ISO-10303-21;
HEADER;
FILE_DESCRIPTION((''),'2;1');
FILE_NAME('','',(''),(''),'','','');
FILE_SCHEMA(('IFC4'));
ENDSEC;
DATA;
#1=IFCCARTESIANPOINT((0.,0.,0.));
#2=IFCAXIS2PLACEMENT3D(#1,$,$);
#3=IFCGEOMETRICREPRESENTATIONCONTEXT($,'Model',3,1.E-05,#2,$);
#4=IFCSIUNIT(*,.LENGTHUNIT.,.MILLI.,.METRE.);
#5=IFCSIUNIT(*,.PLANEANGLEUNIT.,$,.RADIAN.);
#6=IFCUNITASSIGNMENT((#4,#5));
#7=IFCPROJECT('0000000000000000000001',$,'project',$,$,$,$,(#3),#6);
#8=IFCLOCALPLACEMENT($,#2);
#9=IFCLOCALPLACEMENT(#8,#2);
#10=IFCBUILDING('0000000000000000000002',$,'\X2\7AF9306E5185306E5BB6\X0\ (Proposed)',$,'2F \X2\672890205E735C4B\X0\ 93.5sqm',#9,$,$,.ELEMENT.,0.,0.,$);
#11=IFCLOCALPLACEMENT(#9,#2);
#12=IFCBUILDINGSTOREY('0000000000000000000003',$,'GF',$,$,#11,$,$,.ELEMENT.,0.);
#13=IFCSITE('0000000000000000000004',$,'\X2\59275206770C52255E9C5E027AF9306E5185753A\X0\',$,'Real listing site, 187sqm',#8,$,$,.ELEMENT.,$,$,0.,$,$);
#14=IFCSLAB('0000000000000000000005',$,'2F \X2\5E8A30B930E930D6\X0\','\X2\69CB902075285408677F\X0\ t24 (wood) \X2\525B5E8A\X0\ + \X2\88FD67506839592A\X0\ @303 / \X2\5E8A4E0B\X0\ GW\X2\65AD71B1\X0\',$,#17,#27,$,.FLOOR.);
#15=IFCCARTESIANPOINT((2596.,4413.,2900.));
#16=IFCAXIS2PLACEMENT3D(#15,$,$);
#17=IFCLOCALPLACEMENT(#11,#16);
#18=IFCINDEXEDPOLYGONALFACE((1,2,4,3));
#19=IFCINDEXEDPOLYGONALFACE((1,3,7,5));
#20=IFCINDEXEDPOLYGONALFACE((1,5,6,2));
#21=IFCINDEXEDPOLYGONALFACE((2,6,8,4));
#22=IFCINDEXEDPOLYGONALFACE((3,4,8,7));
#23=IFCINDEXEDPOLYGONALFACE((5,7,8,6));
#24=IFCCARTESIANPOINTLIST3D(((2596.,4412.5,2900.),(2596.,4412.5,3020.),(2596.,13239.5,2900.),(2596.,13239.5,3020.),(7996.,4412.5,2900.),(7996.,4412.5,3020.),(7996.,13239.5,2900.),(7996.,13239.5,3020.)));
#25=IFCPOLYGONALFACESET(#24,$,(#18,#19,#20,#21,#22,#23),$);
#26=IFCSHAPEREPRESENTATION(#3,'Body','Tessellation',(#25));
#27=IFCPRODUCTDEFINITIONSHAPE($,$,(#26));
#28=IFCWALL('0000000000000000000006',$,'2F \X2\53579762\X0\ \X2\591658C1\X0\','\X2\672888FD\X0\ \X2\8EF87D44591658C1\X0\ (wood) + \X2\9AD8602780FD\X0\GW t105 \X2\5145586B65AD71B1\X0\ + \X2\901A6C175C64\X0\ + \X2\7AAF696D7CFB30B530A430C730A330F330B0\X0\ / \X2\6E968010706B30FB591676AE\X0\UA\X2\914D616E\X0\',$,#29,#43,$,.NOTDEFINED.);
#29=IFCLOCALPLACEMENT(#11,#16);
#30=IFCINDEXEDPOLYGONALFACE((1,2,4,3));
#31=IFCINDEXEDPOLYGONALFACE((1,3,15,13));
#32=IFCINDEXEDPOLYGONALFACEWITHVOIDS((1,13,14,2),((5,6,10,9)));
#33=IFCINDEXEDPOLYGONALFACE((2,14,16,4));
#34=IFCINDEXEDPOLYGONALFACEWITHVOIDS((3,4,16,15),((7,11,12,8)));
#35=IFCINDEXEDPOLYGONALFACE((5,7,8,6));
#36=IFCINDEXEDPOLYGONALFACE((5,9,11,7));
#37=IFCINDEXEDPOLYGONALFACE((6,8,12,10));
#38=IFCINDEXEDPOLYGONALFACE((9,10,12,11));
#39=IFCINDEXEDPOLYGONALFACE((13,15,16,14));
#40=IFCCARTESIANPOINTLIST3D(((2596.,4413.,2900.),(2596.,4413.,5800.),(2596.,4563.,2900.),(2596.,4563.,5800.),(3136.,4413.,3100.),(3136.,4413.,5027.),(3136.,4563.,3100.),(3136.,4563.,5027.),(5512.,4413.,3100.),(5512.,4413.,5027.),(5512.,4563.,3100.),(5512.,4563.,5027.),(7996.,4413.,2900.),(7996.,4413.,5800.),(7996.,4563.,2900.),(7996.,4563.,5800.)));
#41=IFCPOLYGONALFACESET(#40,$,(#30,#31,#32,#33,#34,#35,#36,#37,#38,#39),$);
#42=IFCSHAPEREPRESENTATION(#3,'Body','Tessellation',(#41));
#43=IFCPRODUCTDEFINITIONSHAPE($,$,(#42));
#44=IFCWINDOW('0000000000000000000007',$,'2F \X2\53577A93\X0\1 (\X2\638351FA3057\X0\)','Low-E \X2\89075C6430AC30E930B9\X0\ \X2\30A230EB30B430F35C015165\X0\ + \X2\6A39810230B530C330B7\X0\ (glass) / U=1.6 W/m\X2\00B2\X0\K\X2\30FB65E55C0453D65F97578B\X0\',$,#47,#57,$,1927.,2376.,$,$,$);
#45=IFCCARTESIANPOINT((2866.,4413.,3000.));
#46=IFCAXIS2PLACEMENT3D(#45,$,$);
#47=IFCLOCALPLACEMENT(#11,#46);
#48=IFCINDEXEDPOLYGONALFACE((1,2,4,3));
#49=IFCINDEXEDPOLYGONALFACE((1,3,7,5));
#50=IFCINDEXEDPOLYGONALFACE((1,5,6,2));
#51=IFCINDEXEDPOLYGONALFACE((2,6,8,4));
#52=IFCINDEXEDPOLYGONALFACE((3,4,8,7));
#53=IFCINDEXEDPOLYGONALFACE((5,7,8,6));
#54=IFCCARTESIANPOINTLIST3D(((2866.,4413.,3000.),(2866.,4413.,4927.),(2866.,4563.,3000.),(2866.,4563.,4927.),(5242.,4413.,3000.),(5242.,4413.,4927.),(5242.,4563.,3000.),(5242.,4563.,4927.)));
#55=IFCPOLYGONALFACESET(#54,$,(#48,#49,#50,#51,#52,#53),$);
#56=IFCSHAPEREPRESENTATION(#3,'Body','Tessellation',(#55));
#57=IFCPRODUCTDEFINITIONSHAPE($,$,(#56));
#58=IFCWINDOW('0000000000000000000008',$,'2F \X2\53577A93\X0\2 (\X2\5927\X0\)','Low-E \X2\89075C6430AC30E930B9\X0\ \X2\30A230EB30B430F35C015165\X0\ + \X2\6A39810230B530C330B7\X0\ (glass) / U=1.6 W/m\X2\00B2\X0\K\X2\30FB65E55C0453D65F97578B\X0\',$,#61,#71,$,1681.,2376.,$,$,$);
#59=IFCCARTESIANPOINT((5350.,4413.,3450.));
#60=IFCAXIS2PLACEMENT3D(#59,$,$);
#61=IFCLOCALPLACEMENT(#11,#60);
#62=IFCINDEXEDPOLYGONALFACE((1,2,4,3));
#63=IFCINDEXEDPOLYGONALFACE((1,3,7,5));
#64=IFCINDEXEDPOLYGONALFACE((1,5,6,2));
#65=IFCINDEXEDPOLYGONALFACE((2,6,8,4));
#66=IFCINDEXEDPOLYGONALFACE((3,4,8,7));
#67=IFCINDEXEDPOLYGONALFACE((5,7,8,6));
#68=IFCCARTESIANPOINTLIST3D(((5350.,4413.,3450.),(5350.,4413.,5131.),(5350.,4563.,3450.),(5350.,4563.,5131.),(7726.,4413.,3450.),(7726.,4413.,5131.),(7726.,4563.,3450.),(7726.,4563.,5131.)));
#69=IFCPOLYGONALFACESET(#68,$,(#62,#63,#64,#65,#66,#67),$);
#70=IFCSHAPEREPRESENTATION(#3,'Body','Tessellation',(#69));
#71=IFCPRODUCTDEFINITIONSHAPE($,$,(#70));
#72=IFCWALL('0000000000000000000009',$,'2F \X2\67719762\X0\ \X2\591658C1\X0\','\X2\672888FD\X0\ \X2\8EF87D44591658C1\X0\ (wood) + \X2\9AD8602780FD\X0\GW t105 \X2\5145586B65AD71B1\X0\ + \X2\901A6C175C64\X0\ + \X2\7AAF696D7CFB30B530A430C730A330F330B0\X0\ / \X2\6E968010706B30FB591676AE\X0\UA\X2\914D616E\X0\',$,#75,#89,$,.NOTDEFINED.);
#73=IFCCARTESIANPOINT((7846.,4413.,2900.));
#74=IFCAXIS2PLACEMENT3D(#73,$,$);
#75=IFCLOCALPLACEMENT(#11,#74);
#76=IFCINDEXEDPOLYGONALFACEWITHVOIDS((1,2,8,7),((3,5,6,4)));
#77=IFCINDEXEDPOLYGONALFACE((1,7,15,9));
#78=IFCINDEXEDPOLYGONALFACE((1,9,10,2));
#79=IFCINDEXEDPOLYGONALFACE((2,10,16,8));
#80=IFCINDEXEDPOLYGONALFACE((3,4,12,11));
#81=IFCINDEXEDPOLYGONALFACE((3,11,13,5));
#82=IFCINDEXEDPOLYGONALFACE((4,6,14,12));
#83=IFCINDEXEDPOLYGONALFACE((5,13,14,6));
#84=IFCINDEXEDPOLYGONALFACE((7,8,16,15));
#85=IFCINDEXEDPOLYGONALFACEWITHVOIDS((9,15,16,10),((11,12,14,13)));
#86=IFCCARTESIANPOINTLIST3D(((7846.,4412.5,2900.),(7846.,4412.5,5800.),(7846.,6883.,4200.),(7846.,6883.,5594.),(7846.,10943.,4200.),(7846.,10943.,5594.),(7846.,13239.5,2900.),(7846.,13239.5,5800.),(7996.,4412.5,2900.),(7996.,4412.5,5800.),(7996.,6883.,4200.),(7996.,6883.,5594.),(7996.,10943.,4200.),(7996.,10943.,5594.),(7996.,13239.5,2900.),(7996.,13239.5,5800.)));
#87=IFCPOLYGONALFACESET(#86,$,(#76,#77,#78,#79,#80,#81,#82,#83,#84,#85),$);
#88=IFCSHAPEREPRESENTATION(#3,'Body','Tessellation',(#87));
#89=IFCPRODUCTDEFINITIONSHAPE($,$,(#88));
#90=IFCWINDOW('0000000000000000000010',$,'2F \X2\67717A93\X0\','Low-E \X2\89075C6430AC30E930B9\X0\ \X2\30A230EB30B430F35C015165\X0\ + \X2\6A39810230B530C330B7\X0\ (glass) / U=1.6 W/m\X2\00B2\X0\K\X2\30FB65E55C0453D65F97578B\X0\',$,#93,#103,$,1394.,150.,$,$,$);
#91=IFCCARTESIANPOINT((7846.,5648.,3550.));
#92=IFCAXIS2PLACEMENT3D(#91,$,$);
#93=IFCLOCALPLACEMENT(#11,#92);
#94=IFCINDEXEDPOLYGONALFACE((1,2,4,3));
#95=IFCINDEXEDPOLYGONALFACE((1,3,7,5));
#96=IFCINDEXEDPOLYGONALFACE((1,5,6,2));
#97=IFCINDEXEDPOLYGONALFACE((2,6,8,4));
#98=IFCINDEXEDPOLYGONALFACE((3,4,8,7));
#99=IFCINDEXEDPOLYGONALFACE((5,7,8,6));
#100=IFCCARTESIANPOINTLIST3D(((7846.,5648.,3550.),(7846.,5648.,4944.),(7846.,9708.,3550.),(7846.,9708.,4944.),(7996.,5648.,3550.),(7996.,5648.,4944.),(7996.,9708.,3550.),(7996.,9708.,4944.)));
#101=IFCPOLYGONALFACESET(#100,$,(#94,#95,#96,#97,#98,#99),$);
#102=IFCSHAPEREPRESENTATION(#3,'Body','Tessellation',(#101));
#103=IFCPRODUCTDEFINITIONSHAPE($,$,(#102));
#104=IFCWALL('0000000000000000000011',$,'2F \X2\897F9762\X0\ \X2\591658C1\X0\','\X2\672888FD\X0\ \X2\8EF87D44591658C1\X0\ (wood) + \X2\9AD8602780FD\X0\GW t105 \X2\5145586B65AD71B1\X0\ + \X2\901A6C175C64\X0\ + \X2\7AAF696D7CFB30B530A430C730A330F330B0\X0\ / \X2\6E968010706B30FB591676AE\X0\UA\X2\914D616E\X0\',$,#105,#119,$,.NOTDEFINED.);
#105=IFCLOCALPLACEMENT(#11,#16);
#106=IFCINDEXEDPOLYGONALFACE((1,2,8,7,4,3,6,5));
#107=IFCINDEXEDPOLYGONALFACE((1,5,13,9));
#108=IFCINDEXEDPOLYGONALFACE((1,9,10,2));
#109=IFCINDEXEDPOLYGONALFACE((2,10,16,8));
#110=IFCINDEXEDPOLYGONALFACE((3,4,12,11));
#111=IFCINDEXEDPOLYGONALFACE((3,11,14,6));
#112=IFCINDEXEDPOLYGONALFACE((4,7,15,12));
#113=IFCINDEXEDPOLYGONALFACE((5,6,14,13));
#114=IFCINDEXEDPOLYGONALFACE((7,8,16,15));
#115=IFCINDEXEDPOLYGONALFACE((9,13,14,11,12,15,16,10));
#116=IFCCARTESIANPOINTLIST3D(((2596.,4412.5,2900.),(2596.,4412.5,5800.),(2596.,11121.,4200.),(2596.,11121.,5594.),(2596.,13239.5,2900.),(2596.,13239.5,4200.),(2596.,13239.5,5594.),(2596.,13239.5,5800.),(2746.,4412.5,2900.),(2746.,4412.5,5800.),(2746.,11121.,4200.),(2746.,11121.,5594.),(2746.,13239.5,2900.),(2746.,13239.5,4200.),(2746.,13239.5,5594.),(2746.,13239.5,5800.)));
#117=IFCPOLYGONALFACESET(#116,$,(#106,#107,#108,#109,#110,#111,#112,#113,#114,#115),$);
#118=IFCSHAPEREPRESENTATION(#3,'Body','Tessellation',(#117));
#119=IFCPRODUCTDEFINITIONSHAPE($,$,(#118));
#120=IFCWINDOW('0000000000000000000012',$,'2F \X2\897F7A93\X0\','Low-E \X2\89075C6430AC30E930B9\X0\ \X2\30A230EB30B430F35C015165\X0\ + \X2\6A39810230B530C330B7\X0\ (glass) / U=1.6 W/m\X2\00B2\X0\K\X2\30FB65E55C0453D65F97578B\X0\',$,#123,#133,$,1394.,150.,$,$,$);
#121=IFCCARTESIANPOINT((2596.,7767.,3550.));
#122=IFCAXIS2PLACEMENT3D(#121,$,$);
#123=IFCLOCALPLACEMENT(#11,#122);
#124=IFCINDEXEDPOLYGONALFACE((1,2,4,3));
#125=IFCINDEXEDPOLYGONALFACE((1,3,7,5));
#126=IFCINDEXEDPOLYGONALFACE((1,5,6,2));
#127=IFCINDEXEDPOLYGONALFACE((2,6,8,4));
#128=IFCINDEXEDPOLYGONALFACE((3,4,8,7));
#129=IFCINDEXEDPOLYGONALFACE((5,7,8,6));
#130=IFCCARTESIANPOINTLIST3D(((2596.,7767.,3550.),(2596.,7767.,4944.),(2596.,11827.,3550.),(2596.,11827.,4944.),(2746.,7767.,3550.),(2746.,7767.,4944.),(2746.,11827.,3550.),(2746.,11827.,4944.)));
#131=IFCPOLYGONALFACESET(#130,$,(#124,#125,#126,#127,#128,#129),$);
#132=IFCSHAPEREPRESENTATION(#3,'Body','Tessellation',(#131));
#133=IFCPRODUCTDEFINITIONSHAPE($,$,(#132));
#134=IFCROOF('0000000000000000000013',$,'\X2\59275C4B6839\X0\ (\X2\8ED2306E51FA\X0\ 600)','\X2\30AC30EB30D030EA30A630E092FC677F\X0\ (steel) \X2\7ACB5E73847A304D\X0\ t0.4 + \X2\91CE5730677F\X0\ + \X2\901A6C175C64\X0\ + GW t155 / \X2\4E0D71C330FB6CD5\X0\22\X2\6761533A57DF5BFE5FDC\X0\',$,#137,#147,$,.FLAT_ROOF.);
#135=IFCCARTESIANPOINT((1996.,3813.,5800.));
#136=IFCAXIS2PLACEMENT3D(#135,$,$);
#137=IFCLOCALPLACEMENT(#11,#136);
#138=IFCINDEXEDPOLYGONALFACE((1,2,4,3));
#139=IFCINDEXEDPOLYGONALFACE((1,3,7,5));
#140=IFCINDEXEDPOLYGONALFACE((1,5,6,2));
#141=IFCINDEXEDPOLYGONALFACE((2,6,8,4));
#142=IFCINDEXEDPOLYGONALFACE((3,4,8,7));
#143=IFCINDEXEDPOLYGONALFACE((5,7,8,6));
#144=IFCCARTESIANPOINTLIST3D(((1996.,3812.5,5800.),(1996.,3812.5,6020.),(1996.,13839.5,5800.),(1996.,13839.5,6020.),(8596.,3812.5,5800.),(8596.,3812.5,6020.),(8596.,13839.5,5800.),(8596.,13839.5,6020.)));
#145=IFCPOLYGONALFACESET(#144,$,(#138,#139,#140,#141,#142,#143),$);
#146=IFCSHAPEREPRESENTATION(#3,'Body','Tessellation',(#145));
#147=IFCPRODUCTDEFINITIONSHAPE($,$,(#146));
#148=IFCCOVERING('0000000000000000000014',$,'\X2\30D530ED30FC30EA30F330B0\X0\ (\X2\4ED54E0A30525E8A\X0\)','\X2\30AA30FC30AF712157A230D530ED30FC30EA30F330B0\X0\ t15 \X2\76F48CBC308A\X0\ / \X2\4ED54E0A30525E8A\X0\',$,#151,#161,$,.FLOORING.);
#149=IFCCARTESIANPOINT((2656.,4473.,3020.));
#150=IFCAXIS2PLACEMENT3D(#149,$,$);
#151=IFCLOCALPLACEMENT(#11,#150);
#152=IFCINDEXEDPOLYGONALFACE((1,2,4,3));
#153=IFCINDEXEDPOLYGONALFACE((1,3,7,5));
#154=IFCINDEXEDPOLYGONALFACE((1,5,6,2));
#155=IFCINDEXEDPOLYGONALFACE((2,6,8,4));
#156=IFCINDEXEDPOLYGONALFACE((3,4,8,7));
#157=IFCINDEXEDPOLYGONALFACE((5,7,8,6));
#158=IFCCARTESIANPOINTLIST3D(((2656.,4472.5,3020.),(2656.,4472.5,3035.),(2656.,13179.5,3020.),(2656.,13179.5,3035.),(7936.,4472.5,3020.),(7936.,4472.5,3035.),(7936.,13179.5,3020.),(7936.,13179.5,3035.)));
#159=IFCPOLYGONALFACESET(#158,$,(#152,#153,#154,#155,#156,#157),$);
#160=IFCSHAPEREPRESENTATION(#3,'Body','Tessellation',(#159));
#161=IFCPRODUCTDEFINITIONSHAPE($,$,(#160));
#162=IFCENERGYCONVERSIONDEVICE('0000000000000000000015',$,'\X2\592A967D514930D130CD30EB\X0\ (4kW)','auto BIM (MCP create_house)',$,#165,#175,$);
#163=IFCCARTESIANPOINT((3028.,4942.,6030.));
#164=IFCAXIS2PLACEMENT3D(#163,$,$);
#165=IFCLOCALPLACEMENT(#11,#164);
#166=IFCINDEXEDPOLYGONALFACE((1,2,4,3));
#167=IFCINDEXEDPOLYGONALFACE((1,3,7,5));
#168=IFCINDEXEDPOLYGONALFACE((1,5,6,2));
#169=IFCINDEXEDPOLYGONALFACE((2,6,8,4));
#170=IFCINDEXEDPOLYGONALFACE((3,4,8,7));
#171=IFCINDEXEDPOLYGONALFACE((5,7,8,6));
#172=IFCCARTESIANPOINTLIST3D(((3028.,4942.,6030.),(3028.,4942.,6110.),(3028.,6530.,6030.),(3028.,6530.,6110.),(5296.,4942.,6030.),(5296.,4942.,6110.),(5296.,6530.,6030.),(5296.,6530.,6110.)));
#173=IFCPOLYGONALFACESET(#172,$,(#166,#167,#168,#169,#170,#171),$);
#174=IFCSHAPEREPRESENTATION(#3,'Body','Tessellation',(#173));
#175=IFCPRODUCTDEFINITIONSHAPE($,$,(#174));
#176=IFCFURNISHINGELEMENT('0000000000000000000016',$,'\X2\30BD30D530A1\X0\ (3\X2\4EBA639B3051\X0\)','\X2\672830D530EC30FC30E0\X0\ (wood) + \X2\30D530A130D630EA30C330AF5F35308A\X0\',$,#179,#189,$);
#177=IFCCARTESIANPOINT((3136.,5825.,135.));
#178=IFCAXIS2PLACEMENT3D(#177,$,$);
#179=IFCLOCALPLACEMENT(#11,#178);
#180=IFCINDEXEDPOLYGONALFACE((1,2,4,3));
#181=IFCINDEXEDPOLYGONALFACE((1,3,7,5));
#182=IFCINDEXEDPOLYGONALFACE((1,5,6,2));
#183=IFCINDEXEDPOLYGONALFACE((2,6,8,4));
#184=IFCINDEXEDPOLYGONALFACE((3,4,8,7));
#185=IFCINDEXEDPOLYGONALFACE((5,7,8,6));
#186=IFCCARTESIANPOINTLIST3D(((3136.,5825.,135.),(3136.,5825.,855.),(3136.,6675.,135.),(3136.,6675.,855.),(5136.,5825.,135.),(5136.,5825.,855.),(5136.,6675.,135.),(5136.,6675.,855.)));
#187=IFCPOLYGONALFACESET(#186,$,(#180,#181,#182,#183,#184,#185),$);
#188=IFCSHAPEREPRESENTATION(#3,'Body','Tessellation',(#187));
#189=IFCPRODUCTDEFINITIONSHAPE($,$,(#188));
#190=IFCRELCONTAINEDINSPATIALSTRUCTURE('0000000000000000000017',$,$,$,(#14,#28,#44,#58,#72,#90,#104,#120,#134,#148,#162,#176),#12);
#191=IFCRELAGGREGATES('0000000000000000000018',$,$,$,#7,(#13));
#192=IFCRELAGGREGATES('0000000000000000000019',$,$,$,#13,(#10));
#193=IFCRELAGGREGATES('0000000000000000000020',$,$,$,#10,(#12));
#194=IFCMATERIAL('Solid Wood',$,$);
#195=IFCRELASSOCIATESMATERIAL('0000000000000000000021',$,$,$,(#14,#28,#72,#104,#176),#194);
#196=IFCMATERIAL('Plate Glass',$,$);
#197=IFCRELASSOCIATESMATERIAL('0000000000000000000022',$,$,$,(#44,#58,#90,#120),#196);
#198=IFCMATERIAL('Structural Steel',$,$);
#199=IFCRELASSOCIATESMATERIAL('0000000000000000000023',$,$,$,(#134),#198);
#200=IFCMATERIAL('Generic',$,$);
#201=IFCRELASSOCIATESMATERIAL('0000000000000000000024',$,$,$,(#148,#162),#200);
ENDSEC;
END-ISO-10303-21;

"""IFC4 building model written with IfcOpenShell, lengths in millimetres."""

from ifc_helpers import new_model, si_unit, frame, frame_2d, origin, place, context, project, spatial, rectangle, extrude, material, element, fill, save


model = new_model("IFC4")

# Units and contexts
model_context = context("Model", 3, precision=1e-05, world=origin())
ifc_project = project(units=[si_unit("LENGTHUNIT", "METRE", prefix="MILLI"), si_unit("PLANEANGLEUNIT", "RADIAN")], contexts=[model_context])

# Site, building, storey
site_placement = place(None, origin())
site = spatial("IfcSite", under=ifc_project, at=site_placement, Name="大分県別府市竹の内町", ObjectType="Real listing site, 187sqm", CompositionType="ELEMENT", RefElevation=0.0)
building_placement = place(site_placement, origin())
building = spatial("IfcBuilding", under=site, at=building_placement, Name="竹の内の家 (Proposed)", ObjectType="2F 木造平屋 93.5sqm", CompositionType="ELEMENT", ElevationOfRefHeight=0.0, ElevationOfTerrain=0.0)
storey_placement = place(building_placement, origin())
storey = spatial("IfcBuildingStorey", under=building, at=storey_placement, Name="GF", CompositionType="ELEMENT", Elevation=0.0)

# Slab
ifc_material_1 = material(Name="Solid Wood")
slab_placement = place(storey_placement, frame((2596.0, 4413.0, 2900.0)))
element("IfcSlab", 1, at=slab_placement, inside=storey, material=ifc_material_1, Name="2F 床スラブ", Description="構造用合板 t24 (wood) 剛床 + 製材根太 @303 / 床下 GW断熱", PredefinedType="FLOOR", context=model_context, shape_type="SweptSolid", body=[
    extrude(rectangle(XDim=5400.0, YDim=8827.0, at=frame_2d((2700.0, 4413.0))), frame((2596.0, 4413.0, 2900.0)), (0.0, 0.0, 1.0), 120.0),
])

# Wall, openings, windows
wall_1_placement = place(storey_placement, frame((2596.0, 4413.0, 2900.0)))
wall_1 = element("IfcWall", 2, at=wall_1_placement, inside=storey, material=ifc_material_1, Name="2F 南面 外壁", Description="木製 軸組外壁 (wood) + 高性能GW t105 充填断熱 + 通気層 + 窯業系サイディング / 準耐火・外皮UA配慮", PredefinedType="NOTDEFINED", context=model_context, shape_type="SweptSolid", body=[
    extrude(rectangle(XDim=5400.0, YDim=150.0, at=frame_2d((2700.0, 75.0))), frame((2596.0, 4413.0, 2900.0)), (0.0, 0.0, 1.0), 2900.0),
])
opening_1_placement = place(storey_placement, frame((2866.0, 4413.0, 3000.0)))
opening_1 = element("IfcOpeningElement", 3, at=opening_1_placement, cuts=wall_1, PredefinedType="NOTDEFINED", context=model_context, shape_type="SweptSolid", body=[
    extrude(rectangle(XDim=2376.0, YDim=150.0, at=frame_2d((1188.0, 75.0))), frame((2866.0, 4413.0, 3000.0)), (0.0, 0.0, 1.0), 1927.0),
])
opening_2_placement = place(storey_placement, frame((5350.0, 4413.0, 3450.0)))
opening_2 = element("IfcOpeningElement", 4, at=opening_2_placement, cuts=wall_1, PredefinedType="NOTDEFINED", context=model_context, shape_type="SweptSolid", body=[
    extrude(rectangle(XDim=2376.0, YDim=150.0, at=frame_2d((1188.0, 75.0))), frame((5350.0, 4413.0, 3450.0)), (0.0, 0.0, 1.0), 1681.0),
])
ifc_material_2 = material(Name="Plate Glass")
window_1_placement = place(storey_placement, frame((2866.0, 4413.0, 3000.0)))
window_1 = element("IfcWindow", 5, at=window_1_placement, inside=storey, material=ifc_material_2, Name="2F 南窓1 (掃出し)", Description="Low-E 複層ガラス アルゴン封入 + 樹脂サッシ (glass) / U=1.6 W/m²K・日射取得型", OverallHeight=1927.0, OverallWidth=2376.0, context=model_context, shape_type="SweptSolid", body=[
    extrude(rectangle(XDim=2376.0, YDim=150.0, at=frame_2d((1188.0, 75.0))), frame((2866.0, 4413.0, 3000.0)), (0.0, 0.0, 1.0), 1927.0),
])
fill(opening_1, window_1)
window_2_placement = place(storey_placement, frame((5350.0, 4413.0, 3450.0)))
window_2 = element("IfcWindow", 6, at=window_2_placement, inside=storey, material=ifc_material_2, Name="2F 南窓2 (大)", Description="Low-E 複層ガラス アルゴン封入 + 樹脂サッシ (glass) / U=1.6 W/m²K・日射取得型", OverallHeight=1681.0, OverallWidth=2376.0, context=model_context, shape_type="SweptSolid", body=[
    extrude(rectangle(XDim=2376.0, YDim=150.0, at=frame_2d((1188.0, 75.0))), frame((5350.0, 4413.0, 3450.0)), (0.0, 0.0, 1.0), 1681.0),
])
fill(opening_2, window_2)

# Walls, openings, windows
wall_2_placement = place(storey_placement, frame((7846.0, 4413.0, 2900.0)))
wall_2 = element("IfcWall", 7, at=wall_2_placement, inside=storey, material=ifc_material_1, Name="2F 東面 外壁", Description="木製 軸組外壁 (wood) + 高性能GW t105 充填断熱 + 通気層 + 窯業系サイディング / 準耐火・外皮UA配慮", PredefinedType="NOTDEFINED", context=model_context, shape_type="SweptSolid", body=[
    extrude(rectangle(XDim=150.0, YDim=8827.0, at=frame_2d((75.0, 4413.0))), frame((7846.0, 4413.0, 2900.0)), (0.0, 0.0, 1.0), 2900.0),
])
opening_3_placement = place(storey_placement, frame((7846.0, 5648.0, 3550.0)))
opening_3 = element("IfcOpeningElement", 8, at=opening_3_placement, cuts=wall_2, PredefinedType="NOTDEFINED", context=model_context, shape_type="SweptSolid", body=[
    extrude(rectangle(XDim=150.0, YDim=4060.0, at=frame_2d((75.0, 2030.0))), frame((7846.0, 5648.0, 3550.0)), (0.0, 0.0, 1.0), 1394.0),
])
window_3_placement = place(storey_placement, frame((7846.0, 5648.0, 3550.0)))
window_3 = element("IfcWindow", 9, at=window_3_placement, inside=storey, material=ifc_material_2, Name="2F 東窓", Description="Low-E 複層ガラス アルゴン封入 + 樹脂サッシ (glass) / U=1.6 W/m²K・日射取得型", OverallHeight=1394.0, OverallWidth=150.0, context=model_context, shape_type="SweptSolid", body=[
    extrude(rectangle(XDim=150.0, YDim=4060.0, at=frame_2d((75.0, 2030.0))), frame((7846.0, 5648.0, 3550.0)), (0.0, 0.0, 1.0), 1394.0),
])
fill(opening_3, window_3)
wall_3_placement = place(storey_placement, frame((2596.0, 4413.0, 2900.0)))
wall_3 = element("IfcWall", 10, at=wall_3_placement, inside=storey, material=ifc_material_1, Name="2F 西面 外壁", Description="木製 軸組外壁 (wood) + 高性能GW t105 充填断熱 + 通気層 + 窯業系サイディング / 準耐火・外皮UA配慮", PredefinedType="NOTDEFINED", context=model_context, shape_type="SweptSolid", body=[
    extrude(rectangle(XDim=150.0, YDim=8827.0, at=frame_2d((75.0, 4413.0))), frame((2596.0, 4413.0, 2900.0)), (0.0, 0.0, 1.0), 2900.0),
])
opening_4_placement = place(storey_placement, frame((2596.0, 7767.0, 3550.0)))
opening_4 = element("IfcOpeningElement", 11, at=opening_4_placement, cuts=wall_3, PredefinedType="NOTDEFINED", context=model_context, shape_type="SweptSolid", body=[
    extrude(rectangle(XDim=150.0, YDim=4060.0, at=frame_2d((75.0, 2030.0))), frame((2596.0, 7767.0, 3550.0)), (0.0, 0.0, 1.0), 1394.0),
])
window_4_placement = place(storey_placement, frame((2596.0, 7767.0, 3550.0)))
window_4 = element("IfcWindow", 12, at=window_4_placement, inside=storey, material=ifc_material_2, Name="2F 西窓", Description="Low-E 複層ガラス アルゴン封入 + 樹脂サッシ (glass) / U=1.6 W/m²K・日射取得型", OverallHeight=1394.0, OverallWidth=150.0, context=model_context, shape_type="SweptSolid", body=[
    extrude(rectangle(XDim=150.0, YDim=4060.0, at=frame_2d((75.0, 2030.0))), frame((2596.0, 7767.0, 3550.0)), (0.0, 0.0, 1.0), 1394.0),
])
fill(opening_4, window_4)

# Roof
ifc_material_3 = material(Name="Structural Steel")
roof_placement = place(storey_placement, frame((1996.0, 3813.0, 5800.0)))
element("IfcRoof", 13, at=roof_placement, inside=storey, material=ifc_material_3, Name="大屋根 (軒の出 600)", Description="ガルバリウム鋼板 (steel) 立平葺き t0.4 + 野地板 + 通気層 + GW t155 / 不燃・法22条区域対応", PredefinedType="FLAT_ROOF", context=model_context, shape_type="SweptSolid", body=[
    extrude(rectangle(XDim=6600.0, YDim=10027.0, at=frame_2d((3300.0, 5013.0))), frame((1996.0, 3813.0, 5800.0)), (0.0, 0.0, 1.0), 220.0),
])

# Covering
ifc_material_4 = material(Name="Generic")
covering_placement = place(storey_placement, frame((2656.0, 4473.0, 3020.0)))
element("IfcCovering", 14, at=covering_placement, inside=storey, material=ifc_material_4, Name="フローリング (仕上げ床)", Description="オーク無垢フローリング t15 直貼り / 仕上げ床", PredefinedType="FLOORING", context=model_context, shape_type="SweptSolid", body=[
    extrude(rectangle(XDim=5280.0, YDim=8707.0, at=frame_2d((2640.0, 4353.0))), frame((2656.0, 4473.0, 3020.0)), (0.0, 0.0, 1.0), 15.0),
])

# Energy conversion device
energy_conversion_device_placement = place(storey_placement, frame((3028.0, 4942.0, 6030.0)))
element("IfcEnergyConversionDevice", 15, at=energy_conversion_device_placement, inside=storey, material=ifc_material_4, Name="太陽光パネル (4kW)", Description="auto BIM (MCP create_house)", context=model_context, shape_type="SweptSolid", body=[
    extrude(rectangle(XDim=2268.0, YDim=1588.0, at=frame_2d((1134.0, 794.0))), frame((3028.0, 4942.0, 6030.0)), (0.0, 0.0, 1.0), 80.0),
])

# Furnishing element
furnishing_1_placement = place(storey_placement, frame((3136.0, 5825.0, 135.0)))
element("IfcFurnishingElement", 16, at=furnishing_1_placement, inside=storey, material=ifc_material_1, Name="ソファ (3人掛け)", Description="木フレーム (wood) + ファブリック張り", context=model_context, shape_type="SweptSolid", body=[
    extrude(rectangle(XDim=2000.0, YDim=850.0, at=frame_2d((1000.0, 425.0))), frame((3136.0, 5825.0, 135.0)), (0.0, 0.0, 1.0), 720.0),
])

save(model, "model.ifc")
